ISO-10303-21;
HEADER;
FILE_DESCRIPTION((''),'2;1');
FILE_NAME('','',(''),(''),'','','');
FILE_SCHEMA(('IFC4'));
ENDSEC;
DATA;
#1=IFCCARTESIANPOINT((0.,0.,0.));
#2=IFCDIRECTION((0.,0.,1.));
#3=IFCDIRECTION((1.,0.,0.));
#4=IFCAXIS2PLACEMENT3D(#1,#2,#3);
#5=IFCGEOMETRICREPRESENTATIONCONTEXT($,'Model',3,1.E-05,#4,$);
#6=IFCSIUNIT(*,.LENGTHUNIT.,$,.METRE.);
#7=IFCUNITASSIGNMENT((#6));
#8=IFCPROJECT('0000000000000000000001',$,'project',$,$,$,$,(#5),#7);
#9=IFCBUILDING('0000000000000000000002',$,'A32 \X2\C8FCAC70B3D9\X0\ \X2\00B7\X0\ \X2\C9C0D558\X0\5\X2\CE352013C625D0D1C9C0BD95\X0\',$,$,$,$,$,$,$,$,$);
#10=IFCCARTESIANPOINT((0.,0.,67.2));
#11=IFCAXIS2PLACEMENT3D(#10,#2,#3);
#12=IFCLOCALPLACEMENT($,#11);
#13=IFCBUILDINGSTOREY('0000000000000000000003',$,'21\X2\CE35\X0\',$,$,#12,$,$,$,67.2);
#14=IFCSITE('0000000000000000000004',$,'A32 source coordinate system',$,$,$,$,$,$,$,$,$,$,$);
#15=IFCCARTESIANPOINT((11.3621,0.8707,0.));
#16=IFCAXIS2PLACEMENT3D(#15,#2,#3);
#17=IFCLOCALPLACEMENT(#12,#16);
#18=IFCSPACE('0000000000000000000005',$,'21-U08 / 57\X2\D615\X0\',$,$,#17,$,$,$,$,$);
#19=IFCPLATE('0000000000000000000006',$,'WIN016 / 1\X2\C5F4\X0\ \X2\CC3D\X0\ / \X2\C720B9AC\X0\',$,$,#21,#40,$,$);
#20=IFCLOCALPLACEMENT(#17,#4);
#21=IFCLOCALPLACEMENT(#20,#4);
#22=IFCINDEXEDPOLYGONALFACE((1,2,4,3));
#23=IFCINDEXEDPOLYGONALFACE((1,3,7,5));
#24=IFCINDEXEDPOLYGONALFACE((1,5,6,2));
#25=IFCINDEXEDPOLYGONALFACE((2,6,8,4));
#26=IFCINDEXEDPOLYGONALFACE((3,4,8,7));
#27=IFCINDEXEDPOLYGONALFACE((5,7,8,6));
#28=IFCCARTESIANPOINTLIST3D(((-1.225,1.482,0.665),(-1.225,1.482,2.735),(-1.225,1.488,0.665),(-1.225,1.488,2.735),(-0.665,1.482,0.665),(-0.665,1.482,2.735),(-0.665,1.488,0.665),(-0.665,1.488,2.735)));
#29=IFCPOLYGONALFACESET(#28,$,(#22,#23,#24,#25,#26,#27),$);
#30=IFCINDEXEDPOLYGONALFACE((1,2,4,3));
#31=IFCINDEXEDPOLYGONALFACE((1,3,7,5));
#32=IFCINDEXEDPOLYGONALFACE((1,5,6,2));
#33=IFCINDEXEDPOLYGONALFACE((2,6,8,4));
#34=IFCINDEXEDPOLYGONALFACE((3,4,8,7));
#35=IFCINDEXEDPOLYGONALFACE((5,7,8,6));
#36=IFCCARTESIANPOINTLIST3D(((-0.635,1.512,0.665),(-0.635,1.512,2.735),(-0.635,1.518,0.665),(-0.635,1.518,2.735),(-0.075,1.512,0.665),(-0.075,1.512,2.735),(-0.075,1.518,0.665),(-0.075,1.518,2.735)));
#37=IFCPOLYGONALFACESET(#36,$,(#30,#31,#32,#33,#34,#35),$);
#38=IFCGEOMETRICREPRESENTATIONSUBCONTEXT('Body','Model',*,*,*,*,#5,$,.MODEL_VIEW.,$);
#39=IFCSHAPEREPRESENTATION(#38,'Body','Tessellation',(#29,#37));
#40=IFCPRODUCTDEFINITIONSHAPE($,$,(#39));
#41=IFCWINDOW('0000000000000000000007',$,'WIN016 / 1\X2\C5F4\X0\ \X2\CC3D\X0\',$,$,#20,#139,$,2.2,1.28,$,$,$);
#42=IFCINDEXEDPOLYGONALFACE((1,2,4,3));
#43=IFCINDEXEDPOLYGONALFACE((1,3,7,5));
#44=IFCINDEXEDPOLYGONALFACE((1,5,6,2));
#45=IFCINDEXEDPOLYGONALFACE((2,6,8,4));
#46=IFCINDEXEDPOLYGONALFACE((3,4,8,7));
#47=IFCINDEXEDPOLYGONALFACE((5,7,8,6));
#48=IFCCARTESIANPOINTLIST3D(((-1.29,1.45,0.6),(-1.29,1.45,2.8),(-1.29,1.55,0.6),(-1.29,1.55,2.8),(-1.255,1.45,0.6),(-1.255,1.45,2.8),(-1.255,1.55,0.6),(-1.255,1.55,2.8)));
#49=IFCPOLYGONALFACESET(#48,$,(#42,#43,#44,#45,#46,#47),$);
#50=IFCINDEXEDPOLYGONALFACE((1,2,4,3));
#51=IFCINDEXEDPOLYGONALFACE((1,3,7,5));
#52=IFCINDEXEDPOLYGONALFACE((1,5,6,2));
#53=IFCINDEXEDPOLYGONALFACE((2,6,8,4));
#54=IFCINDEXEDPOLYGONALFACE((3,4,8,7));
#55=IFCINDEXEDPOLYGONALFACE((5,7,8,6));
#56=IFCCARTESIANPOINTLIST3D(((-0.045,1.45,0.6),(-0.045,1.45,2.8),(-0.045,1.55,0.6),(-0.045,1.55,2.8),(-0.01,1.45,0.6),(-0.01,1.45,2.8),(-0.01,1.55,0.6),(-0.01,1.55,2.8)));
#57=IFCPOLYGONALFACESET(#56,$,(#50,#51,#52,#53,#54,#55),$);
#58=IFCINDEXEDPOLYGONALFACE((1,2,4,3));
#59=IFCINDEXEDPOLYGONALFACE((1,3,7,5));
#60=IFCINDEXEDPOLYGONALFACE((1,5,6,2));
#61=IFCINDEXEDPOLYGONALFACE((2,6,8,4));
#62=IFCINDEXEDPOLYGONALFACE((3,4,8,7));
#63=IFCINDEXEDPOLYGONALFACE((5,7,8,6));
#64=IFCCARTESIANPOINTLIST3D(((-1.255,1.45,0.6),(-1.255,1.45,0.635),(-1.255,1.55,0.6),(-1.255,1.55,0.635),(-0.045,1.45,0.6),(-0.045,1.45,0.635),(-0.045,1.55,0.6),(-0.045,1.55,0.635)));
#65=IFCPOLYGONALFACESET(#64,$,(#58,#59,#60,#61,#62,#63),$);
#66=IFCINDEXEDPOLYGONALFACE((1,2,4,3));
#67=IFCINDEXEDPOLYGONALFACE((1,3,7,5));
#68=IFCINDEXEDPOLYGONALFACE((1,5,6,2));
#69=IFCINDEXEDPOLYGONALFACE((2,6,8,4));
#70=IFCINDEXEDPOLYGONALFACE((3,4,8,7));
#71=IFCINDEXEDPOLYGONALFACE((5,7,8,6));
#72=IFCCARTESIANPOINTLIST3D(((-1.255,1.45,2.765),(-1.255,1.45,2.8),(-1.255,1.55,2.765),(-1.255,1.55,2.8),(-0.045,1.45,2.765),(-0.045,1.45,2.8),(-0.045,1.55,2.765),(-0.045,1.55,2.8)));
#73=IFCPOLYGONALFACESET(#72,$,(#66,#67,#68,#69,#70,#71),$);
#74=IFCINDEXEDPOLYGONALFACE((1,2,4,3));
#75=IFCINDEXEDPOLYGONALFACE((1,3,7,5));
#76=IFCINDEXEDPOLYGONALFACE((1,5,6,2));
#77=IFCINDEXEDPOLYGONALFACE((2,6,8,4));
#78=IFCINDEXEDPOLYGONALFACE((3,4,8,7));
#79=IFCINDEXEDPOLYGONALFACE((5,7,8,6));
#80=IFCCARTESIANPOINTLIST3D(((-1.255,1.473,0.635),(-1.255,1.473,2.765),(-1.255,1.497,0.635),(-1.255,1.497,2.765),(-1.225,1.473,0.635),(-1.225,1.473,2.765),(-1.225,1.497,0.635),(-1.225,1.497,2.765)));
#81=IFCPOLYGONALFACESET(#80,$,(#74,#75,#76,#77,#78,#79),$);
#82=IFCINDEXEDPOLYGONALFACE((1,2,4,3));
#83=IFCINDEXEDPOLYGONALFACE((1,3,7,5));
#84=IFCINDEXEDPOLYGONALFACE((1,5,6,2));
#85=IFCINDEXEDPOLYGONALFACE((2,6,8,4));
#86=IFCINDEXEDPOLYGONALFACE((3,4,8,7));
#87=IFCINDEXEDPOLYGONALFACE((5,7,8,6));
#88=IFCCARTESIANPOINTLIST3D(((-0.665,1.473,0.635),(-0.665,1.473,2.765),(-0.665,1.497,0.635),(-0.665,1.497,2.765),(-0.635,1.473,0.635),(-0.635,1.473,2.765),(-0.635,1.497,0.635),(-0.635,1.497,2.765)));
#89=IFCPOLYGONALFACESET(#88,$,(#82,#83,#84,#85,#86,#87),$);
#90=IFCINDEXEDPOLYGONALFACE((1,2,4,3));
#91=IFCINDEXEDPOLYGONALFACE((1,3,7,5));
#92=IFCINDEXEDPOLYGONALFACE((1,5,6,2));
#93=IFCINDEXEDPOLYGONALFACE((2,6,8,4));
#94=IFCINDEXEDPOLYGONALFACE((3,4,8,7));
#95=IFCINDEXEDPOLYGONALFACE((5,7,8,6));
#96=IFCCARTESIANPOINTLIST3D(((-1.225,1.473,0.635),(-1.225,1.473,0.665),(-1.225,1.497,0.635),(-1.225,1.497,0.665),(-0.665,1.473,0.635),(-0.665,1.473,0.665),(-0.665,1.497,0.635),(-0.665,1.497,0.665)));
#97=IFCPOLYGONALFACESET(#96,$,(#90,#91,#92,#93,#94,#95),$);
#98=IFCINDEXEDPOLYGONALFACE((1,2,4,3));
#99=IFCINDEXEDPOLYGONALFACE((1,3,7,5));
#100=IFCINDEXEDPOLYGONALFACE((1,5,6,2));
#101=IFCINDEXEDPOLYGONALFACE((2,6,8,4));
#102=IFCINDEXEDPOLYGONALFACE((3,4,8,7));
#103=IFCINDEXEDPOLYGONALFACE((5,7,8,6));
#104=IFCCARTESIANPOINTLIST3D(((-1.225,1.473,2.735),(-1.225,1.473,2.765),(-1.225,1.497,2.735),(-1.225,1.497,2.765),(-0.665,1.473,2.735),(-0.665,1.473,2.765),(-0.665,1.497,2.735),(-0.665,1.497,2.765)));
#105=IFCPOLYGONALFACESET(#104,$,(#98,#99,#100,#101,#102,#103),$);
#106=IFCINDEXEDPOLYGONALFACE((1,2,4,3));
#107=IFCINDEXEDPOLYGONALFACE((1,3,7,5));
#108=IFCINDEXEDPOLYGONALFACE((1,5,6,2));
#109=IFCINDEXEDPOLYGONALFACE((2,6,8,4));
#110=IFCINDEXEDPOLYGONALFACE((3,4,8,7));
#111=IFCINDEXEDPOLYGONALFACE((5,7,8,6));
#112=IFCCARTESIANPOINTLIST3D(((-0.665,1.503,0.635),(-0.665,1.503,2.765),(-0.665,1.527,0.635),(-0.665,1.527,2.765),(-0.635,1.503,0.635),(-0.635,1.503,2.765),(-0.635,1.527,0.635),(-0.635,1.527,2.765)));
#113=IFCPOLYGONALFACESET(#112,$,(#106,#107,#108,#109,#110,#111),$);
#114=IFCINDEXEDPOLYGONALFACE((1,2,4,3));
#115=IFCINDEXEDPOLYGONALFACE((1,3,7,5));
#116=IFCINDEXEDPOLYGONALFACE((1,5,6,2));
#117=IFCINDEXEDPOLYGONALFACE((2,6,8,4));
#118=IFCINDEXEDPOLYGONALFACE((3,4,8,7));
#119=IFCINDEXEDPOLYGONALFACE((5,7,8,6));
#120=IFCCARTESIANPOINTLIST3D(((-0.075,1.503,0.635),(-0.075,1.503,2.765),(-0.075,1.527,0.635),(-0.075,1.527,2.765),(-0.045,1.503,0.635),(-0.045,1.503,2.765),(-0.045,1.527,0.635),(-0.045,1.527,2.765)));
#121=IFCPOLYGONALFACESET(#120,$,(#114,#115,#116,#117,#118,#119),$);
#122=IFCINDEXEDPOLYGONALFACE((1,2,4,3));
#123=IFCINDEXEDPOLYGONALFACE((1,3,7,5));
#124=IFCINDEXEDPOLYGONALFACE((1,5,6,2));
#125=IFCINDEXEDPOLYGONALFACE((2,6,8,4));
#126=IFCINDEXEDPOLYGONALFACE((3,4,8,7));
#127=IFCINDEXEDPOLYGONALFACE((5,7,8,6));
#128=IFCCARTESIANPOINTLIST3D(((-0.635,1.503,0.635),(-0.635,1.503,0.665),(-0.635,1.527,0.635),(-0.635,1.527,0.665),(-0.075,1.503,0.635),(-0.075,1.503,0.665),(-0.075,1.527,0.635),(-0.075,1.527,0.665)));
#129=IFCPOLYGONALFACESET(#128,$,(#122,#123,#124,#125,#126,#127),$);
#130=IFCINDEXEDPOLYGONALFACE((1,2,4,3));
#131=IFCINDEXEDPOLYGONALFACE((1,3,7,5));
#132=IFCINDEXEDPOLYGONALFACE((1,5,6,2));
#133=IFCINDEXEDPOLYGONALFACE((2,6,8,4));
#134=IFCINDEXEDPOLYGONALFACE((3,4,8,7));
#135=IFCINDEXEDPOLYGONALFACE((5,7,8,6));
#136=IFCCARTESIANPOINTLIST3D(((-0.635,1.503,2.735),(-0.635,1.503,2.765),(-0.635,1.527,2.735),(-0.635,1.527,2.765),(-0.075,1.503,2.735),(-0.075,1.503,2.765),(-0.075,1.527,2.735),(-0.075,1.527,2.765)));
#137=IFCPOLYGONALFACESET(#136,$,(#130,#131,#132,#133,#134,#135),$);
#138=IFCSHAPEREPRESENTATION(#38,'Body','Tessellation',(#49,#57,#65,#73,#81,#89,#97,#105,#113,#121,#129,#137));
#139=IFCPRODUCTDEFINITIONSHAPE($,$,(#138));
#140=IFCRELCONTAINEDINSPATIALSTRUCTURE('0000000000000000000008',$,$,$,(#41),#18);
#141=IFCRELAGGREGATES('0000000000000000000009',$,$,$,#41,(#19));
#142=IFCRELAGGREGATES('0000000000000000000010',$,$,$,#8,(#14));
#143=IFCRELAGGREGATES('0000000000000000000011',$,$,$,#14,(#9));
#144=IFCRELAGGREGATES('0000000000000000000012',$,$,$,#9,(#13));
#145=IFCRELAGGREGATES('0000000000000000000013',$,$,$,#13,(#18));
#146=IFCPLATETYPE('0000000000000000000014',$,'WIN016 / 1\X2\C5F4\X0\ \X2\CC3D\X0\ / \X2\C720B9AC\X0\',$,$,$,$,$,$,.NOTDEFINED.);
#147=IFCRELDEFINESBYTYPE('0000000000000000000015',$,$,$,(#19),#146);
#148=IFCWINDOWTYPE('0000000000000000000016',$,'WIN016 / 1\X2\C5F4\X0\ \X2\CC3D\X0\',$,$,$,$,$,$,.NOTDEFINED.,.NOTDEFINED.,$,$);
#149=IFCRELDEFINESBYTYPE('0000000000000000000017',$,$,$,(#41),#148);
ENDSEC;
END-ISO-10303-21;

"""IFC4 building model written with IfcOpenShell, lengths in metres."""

from ifc_helpers import new_model, si_unit, frame, origin, origin_with_axes, place, context, subcontext, project, spatial, polyline, outline, extrude, source, transform, mapped, type_object, type_shapes, element, aggregate, save


model = new_model("IFC4")

# Units and contexts
model_context = context("Model", 3, precision=1e-05, world=origin_with_axes())
body_context = subcontext(model_context, "Body", "Model", "MODEL_VIEW")
ifc_project = project(units=[si_unit("LENGTHUNIT", "METRE")], contexts=[model_context])

# Plate
storey_placement = place(None, frame((0.0, 0.0, 67.2), z_axis=(0.0, 0.0, 1.0), x_axis=(1.0, 0.0, 0.0)))
space_placement = place(storey_placement, frame((11.3621, 0.8707, 0.0), z_axis=(0.0, 0.0, 1.0), x_axis=(1.0, 0.0, 0.0)))
plate_type_1 = type_object("IfcPlateType", Name="WIN016 / 1열 창 / 유리", PredefinedType="NOTDEFINED")
shared_shape_1 = source(origin(), body_context, "Body", "SweptSolid", [
    extrude(outline(polyline([(-1.225, 1.482), (-1.225, 1.488), (-0.665, 1.488), (-0.665, 1.482), (-1.225, 1.482)])), frame((0.0, 0.0, 0.665)), (0.0, 0.0, 1.0), 2.07),
    extrude(outline(polyline([(-0.635, 1.512), (-0.635, 1.518), (-0.075, 1.518), (-0.075, 1.512), (-0.635, 1.512)])), frame((0.0, 0.0, 0.665)), (0.0, 0.0, 1.0), 2.07),
])
type_shapes(plate_type_1, [shared_shape_1])
window_1_placement = place(space_placement, origin_with_axes())
plate_1_placement = place(window_1_placement, origin_with_axes())
plate_1 = element("IfcPlate", 1, at=plate_1_placement, type_object=plate_type_1, Name="WIN016 / 1열 창 / 유리", context=body_context, shape_type="MappedRepresentation", body=[
    mapped(shared_shape_1, transform((0.0, 0.0, 0.0), scale=1.0)),
])

# Site, building, storey, space
site = spatial("IfcSite", under=ifc_project, Name="A32 source coordinate system")
building = spatial("IfcBuilding", under=site, Name="A32 주거동 · 지하5층–옥탑지붕")
storey = spatial("IfcBuildingStorey", under=building, at=storey_placement, Name="21층", Elevation=67.2)
space = spatial("IfcSpace", under=storey, at=space_placement, Name="21-U08 / 57형")

# Window
window_type_1 = type_object("IfcWindowType", Name="WIN016 / 1열 창", PartitioningType="NOTDEFINED", PredefinedType="NOTDEFINED")
shared_shape_2 = source(origin(), body_context, "Body", "SweptSolid", [
    extrude(outline(polyline([(-1.29, 1.45), (-1.29, 1.55), (-1.255, 1.55), (-1.255, 1.45), (-1.29, 1.45)])), frame((0.0, 0.0, 0.6)), (0.0, 0.0, 1.0), 2.2),
    extrude(outline(polyline([(-0.045, 1.45), (-0.045, 1.55), (-0.01, 1.55), (-0.01, 1.45), (-0.045, 1.45)])), frame((0.0, 0.0, 0.6)), (0.0, 0.0, 1.0), 2.2),
    extrude(outline(polyline([(-1.255, 1.45), (-1.255, 1.55), (-0.045, 1.55), (-0.045, 1.45), (-1.255, 1.45)])), frame((0.0, 0.0, 0.6)), (0.0, 0.0, 1.0), 0.035),
    extrude(outline(polyline([(-1.255, 1.45), (-1.255, 1.55), (-0.045, 1.55), (-0.045, 1.45), (-1.255, 1.45)])), frame((0.0, 0.0, 2.765)), (0.0, 0.0, 1.0), 0.035),
    extrude(outline(polyline([(-1.255, 1.473), (-1.255, 1.497), (-1.225, 1.497), (-1.225, 1.473), (-1.255, 1.473)])), frame((0.0, 0.0, 0.635)), (0.0, 0.0, 1.0), 2.13),
    extrude(outline(polyline([(-0.665, 1.473), (-0.665, 1.497), (-0.635, 1.497), (-0.635, 1.473), (-0.665, 1.473)])), frame((0.0, 0.0, 0.635)), (0.0, 0.0, 1.0), 2.13),
    extrude(outline(polyline([(-1.225, 1.473), (-1.225, 1.497), (-0.665, 1.497), (-0.665, 1.473), (-1.225, 1.473)])), frame((0.0, 0.0, 0.635)), (0.0, 0.0, 1.0), 0.03),
    extrude(outline(polyline([(-1.225, 1.473), (-1.225, 1.497), (-0.665, 1.497), (-0.665, 1.473), (-1.225, 1.473)])), frame((0.0, 0.0, 2.735)), (0.0, 0.0, 1.0), 0.03),
    extrude(outline(polyline([(-0.665, 1.503), (-0.665, 1.527), (-0.635, 1.527), (-0.635, 1.503), (-0.665, 1.503)])), frame((0.0, 0.0, 0.635)), (0.0, 0.0, 1.0), 2.13),
    extrude(outline(polyline([(-0.075, 1.503), (-0.075, 1.527), (-0.045, 1.527), (-0.045, 1.503), (-0.075, 1.503)])), frame((0.0, 0.0, 0.635)), (0.0, 0.0, 1.0), 2.13),
    extrude(outline(polyline([(-0.635, 1.503), (-0.635, 1.527), (-0.075, 1.527), (-0.075, 1.503), (-0.635, 1.503)])), frame((0.0, 0.0, 0.635)), (0.0, 0.0, 1.0), 0.03),
    extrude(outline(polyline([(-0.635, 1.503), (-0.635, 1.527), (-0.075, 1.527), (-0.075, 1.503), (-0.635, 1.503)])), frame((0.0, 0.0, 2.735)), (0.0, 0.0, 1.0), 0.03),
])
type_shapes(window_type_1, [shared_shape_2])
window_1 = element("IfcWindow", 2, at=window_1_placement, inside=space, type_object=window_type_1, Name="WIN016 / 1열 창", OverallHeight=2.2, OverallWidth=1.28, context=body_context, shape_type="MappedRepresentation", body=[
    mapped(shared_shape_2, transform((0.0, 0.0, 0.0), scale=1.0)),
])
aggregate(window_1, [plate_1])

save(model, "model.ifc")
